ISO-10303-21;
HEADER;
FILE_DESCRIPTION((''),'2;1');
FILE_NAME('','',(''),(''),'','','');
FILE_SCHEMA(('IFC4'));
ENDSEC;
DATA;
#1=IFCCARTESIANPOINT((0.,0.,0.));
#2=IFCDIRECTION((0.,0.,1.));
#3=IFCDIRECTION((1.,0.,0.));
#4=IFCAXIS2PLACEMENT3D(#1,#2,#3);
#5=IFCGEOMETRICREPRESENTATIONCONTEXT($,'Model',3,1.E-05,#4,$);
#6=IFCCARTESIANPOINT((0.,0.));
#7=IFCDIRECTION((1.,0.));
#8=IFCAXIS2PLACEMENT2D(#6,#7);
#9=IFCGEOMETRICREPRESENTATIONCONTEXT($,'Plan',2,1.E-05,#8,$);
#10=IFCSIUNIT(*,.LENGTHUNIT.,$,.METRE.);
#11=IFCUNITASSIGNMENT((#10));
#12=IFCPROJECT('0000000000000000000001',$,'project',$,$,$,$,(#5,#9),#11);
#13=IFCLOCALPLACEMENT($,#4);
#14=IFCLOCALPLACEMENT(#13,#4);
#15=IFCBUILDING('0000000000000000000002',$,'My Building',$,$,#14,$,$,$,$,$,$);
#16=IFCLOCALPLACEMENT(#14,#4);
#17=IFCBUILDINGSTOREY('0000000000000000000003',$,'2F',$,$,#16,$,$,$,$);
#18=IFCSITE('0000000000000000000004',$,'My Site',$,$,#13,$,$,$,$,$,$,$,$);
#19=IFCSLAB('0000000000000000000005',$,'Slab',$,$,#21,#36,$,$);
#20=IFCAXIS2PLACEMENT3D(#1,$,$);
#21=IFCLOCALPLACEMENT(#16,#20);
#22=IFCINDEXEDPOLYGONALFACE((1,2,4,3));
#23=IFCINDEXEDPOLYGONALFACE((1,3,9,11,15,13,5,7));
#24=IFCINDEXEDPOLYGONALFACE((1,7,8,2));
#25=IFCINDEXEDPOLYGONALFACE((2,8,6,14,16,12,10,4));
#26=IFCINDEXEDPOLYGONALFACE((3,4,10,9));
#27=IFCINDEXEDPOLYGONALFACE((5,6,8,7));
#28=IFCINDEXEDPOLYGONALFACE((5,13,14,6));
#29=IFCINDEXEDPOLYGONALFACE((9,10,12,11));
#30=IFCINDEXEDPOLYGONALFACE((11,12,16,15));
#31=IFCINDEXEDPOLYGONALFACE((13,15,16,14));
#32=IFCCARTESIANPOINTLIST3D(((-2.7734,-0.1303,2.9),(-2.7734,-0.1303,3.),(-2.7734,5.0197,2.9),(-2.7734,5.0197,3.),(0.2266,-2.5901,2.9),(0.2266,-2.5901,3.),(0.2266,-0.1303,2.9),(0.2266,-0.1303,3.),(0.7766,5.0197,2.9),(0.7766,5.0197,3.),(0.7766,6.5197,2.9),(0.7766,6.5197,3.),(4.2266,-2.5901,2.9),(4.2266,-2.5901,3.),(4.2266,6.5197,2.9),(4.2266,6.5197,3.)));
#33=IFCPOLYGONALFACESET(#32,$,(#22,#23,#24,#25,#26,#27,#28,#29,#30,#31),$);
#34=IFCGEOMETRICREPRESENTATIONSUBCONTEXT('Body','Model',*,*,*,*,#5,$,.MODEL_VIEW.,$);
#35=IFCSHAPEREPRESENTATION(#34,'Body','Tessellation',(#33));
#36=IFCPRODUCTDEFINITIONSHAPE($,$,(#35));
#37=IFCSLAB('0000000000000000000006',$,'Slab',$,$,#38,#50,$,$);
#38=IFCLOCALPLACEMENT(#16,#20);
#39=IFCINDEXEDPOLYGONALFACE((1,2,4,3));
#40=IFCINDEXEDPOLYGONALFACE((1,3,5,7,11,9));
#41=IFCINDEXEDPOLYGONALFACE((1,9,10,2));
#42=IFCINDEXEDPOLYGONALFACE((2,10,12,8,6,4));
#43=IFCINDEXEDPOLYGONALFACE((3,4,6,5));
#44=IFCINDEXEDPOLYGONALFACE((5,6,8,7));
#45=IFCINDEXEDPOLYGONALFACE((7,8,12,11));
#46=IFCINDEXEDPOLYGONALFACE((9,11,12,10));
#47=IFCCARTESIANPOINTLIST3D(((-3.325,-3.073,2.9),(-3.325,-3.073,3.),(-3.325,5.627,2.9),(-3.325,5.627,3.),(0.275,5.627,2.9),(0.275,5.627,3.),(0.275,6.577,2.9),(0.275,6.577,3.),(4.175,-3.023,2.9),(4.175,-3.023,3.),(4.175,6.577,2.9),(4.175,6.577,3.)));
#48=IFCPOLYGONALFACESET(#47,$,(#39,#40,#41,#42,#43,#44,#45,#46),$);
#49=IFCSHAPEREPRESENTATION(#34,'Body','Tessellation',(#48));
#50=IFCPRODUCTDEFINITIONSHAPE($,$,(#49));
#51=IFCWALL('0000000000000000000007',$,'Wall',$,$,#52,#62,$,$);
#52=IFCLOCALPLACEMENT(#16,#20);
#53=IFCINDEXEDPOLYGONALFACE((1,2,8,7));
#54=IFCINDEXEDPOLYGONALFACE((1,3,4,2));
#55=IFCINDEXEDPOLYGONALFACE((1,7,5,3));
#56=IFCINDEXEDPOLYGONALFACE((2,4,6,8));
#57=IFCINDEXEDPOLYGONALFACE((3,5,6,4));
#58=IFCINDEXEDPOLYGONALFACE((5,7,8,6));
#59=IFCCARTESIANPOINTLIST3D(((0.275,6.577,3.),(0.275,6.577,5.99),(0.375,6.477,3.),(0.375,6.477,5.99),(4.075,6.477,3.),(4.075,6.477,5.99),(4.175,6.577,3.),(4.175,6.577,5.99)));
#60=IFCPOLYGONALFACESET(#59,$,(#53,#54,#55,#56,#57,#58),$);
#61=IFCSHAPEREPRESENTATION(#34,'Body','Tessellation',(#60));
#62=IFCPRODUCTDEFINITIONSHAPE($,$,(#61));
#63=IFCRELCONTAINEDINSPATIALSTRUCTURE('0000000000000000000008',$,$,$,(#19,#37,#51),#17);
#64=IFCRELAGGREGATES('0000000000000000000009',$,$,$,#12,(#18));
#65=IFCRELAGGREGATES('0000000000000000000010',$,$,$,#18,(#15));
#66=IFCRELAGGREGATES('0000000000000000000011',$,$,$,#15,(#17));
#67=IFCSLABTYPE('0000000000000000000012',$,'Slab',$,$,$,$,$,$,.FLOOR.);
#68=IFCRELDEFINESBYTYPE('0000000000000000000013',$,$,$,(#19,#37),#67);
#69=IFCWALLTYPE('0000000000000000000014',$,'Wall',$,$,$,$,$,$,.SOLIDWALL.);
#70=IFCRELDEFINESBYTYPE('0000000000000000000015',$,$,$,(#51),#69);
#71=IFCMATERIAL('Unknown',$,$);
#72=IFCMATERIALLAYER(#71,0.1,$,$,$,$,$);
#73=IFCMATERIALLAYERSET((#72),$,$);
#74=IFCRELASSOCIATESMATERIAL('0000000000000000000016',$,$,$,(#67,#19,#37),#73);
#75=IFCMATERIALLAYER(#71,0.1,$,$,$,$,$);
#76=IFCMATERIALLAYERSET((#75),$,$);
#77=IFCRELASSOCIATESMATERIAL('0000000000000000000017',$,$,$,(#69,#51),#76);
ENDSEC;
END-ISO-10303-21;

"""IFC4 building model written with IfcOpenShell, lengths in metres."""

from ifc_helpers import new_model, si_unit, frame, origin_with_axes, origin_2d_with_axis, place, context, subcontext, project, spatial, line, indexed_curve, outline, extrude, material, layer, layer_set, layer_usage, type_object, element, save


model = new_model("IFC4")

# Units and contexts
model_context = context("Model", 3, precision=1e-05, world=origin_with_axes())
plan_context = context("Plan", 2, precision=1e-05, world=origin_2d_with_axis())
body_context_1 = subcontext(model_context, "Body", "Model", "MODEL_VIEW")
ifc_project = project(units=[si_unit("LENGTHUNIT", "METRE")], contexts=[model_context, plan_context])

# Site, building, storey
site_placement = place(None, origin_with_axes())
site = spatial("IfcSite", under=ifc_project, at=site_placement, Name="My Site")
building_placement = place(site_placement, origin_with_axes())
building = spatial("IfcBuilding", under=site, at=building_placement, Name="My Building")
storey_placement = place(building_placement, origin_with_axes())
storey = spatial("IfcBuildingStorey", under=building, at=storey_placement, Name="2F")

# Slabs
ifc_material = material(Name="Unknown")
ifc_layer_1 = layer(ifc_material, 0.1)
ifc_layer_set_1 = layer_set([ifc_layer_1])
ifc_layer_usage_1 = layer_usage(ifc_layer_set_1, "AXIS3", "POSITIVE", -0.1)
slab_type = type_object("IfcSlabType", Name="Slab", PredefinedType="FLOOR", material=ifc_layer_set_1)
slab_1_placement = place(storey_placement, frame((4.2266, -2.5901, 3.0), z_axis=(0.0, 0.0, 1.0), x_axis=(1.0, 0.0, 0.0)))
element("IfcSlab", 1, at=slab_1_placement, inside=storey, type_object=slab_type, material=ifc_layer_usage_1, Name="Slab", context=body_context_1, shape_type="SweptSolid", body=[
    extrude(outline(indexed_curve([(0.0, 0.0), (0.0, 9.1098), (-3.45, 9.1098), (-3.45, 7.6098), (-7.0, 7.6098), (-7.0, 2.4598), (-4.0, 2.4598), (-4.0, 0.0), (0.0, 0.0)])), frame((0.0, 0.0, -0.1), z_axis=(0.0, 0.0, 1.0), x_axis=(1.0, 0.0, 0.0)), (0.0, 0.0, 1.0), 0.1),
])
ifc_layer_usage_2 = layer_usage(ifc_layer_set_1, "AXIS3", "POSITIVE", -0.1)
slab_2_placement = place(storey_placement, frame((4.175, -3.023, 3.0), z_axis=(0.0, 0.0, 1.0), x_axis=(1.0, 0.0, 0.0)))
element("IfcSlab", 2, at=slab_2_placement, inside=storey, type_object=slab_type, material=ifc_layer_usage_2, Name="Slab", context=body_context_1, shape_type="SweptSolid", body=[
    extrude(outline(indexed_curve([(0.0, 0.0), (0.0, 9.6), (-3.9, 9.6), (-3.9, 8.65), (-7.5, 8.65), (-7.5, -0.05), (0.0, 0.0)])), frame((0.0, 0.0, -0.1), z_axis=(0.0, 0.0, 1.0), x_axis=(1.0, 0.0, 0.0)), (0.0, 0.0, 1.0), 0.1),
])

# Wall
ifc_layer_2 = layer(ifc_material, 0.1)
ifc_layer_set_2 = layer_set([ifc_layer_2])
ifc_layer_usage_3 = layer_usage(ifc_layer_set_2, "AXIS2", "POSITIVE", 0.0)
wall_type = type_object("IfcWallType", Name="Wall", PredefinedType="SOLIDWALL", material=ifc_layer_set_2)
wall_1_placement = place(storey_placement, frame((4.175, 6.577, 3.0), z_axis=(0.0, 0.0, 1.0), x_axis=(-1.0, 0.0, 0.0)))
element("IfcWall", 3, at=wall_1_placement, inside=storey, type_object=wall_type, material=ifc_layer_usage_3, Name="Wall", context=body_context_1, shape_type="SweptSolid", body=[
    extrude(outline(indexed_curve([(0.0, 0.0), (0.1, 0.1), (3.8, 0.1), (3.9, 0.0)], segments=[line(1, 2, 3, 4, 1)])), origin_with_axes(), (0.0, 0.0, 1.0), 2.99),
])

save(model, "model.ifc")
